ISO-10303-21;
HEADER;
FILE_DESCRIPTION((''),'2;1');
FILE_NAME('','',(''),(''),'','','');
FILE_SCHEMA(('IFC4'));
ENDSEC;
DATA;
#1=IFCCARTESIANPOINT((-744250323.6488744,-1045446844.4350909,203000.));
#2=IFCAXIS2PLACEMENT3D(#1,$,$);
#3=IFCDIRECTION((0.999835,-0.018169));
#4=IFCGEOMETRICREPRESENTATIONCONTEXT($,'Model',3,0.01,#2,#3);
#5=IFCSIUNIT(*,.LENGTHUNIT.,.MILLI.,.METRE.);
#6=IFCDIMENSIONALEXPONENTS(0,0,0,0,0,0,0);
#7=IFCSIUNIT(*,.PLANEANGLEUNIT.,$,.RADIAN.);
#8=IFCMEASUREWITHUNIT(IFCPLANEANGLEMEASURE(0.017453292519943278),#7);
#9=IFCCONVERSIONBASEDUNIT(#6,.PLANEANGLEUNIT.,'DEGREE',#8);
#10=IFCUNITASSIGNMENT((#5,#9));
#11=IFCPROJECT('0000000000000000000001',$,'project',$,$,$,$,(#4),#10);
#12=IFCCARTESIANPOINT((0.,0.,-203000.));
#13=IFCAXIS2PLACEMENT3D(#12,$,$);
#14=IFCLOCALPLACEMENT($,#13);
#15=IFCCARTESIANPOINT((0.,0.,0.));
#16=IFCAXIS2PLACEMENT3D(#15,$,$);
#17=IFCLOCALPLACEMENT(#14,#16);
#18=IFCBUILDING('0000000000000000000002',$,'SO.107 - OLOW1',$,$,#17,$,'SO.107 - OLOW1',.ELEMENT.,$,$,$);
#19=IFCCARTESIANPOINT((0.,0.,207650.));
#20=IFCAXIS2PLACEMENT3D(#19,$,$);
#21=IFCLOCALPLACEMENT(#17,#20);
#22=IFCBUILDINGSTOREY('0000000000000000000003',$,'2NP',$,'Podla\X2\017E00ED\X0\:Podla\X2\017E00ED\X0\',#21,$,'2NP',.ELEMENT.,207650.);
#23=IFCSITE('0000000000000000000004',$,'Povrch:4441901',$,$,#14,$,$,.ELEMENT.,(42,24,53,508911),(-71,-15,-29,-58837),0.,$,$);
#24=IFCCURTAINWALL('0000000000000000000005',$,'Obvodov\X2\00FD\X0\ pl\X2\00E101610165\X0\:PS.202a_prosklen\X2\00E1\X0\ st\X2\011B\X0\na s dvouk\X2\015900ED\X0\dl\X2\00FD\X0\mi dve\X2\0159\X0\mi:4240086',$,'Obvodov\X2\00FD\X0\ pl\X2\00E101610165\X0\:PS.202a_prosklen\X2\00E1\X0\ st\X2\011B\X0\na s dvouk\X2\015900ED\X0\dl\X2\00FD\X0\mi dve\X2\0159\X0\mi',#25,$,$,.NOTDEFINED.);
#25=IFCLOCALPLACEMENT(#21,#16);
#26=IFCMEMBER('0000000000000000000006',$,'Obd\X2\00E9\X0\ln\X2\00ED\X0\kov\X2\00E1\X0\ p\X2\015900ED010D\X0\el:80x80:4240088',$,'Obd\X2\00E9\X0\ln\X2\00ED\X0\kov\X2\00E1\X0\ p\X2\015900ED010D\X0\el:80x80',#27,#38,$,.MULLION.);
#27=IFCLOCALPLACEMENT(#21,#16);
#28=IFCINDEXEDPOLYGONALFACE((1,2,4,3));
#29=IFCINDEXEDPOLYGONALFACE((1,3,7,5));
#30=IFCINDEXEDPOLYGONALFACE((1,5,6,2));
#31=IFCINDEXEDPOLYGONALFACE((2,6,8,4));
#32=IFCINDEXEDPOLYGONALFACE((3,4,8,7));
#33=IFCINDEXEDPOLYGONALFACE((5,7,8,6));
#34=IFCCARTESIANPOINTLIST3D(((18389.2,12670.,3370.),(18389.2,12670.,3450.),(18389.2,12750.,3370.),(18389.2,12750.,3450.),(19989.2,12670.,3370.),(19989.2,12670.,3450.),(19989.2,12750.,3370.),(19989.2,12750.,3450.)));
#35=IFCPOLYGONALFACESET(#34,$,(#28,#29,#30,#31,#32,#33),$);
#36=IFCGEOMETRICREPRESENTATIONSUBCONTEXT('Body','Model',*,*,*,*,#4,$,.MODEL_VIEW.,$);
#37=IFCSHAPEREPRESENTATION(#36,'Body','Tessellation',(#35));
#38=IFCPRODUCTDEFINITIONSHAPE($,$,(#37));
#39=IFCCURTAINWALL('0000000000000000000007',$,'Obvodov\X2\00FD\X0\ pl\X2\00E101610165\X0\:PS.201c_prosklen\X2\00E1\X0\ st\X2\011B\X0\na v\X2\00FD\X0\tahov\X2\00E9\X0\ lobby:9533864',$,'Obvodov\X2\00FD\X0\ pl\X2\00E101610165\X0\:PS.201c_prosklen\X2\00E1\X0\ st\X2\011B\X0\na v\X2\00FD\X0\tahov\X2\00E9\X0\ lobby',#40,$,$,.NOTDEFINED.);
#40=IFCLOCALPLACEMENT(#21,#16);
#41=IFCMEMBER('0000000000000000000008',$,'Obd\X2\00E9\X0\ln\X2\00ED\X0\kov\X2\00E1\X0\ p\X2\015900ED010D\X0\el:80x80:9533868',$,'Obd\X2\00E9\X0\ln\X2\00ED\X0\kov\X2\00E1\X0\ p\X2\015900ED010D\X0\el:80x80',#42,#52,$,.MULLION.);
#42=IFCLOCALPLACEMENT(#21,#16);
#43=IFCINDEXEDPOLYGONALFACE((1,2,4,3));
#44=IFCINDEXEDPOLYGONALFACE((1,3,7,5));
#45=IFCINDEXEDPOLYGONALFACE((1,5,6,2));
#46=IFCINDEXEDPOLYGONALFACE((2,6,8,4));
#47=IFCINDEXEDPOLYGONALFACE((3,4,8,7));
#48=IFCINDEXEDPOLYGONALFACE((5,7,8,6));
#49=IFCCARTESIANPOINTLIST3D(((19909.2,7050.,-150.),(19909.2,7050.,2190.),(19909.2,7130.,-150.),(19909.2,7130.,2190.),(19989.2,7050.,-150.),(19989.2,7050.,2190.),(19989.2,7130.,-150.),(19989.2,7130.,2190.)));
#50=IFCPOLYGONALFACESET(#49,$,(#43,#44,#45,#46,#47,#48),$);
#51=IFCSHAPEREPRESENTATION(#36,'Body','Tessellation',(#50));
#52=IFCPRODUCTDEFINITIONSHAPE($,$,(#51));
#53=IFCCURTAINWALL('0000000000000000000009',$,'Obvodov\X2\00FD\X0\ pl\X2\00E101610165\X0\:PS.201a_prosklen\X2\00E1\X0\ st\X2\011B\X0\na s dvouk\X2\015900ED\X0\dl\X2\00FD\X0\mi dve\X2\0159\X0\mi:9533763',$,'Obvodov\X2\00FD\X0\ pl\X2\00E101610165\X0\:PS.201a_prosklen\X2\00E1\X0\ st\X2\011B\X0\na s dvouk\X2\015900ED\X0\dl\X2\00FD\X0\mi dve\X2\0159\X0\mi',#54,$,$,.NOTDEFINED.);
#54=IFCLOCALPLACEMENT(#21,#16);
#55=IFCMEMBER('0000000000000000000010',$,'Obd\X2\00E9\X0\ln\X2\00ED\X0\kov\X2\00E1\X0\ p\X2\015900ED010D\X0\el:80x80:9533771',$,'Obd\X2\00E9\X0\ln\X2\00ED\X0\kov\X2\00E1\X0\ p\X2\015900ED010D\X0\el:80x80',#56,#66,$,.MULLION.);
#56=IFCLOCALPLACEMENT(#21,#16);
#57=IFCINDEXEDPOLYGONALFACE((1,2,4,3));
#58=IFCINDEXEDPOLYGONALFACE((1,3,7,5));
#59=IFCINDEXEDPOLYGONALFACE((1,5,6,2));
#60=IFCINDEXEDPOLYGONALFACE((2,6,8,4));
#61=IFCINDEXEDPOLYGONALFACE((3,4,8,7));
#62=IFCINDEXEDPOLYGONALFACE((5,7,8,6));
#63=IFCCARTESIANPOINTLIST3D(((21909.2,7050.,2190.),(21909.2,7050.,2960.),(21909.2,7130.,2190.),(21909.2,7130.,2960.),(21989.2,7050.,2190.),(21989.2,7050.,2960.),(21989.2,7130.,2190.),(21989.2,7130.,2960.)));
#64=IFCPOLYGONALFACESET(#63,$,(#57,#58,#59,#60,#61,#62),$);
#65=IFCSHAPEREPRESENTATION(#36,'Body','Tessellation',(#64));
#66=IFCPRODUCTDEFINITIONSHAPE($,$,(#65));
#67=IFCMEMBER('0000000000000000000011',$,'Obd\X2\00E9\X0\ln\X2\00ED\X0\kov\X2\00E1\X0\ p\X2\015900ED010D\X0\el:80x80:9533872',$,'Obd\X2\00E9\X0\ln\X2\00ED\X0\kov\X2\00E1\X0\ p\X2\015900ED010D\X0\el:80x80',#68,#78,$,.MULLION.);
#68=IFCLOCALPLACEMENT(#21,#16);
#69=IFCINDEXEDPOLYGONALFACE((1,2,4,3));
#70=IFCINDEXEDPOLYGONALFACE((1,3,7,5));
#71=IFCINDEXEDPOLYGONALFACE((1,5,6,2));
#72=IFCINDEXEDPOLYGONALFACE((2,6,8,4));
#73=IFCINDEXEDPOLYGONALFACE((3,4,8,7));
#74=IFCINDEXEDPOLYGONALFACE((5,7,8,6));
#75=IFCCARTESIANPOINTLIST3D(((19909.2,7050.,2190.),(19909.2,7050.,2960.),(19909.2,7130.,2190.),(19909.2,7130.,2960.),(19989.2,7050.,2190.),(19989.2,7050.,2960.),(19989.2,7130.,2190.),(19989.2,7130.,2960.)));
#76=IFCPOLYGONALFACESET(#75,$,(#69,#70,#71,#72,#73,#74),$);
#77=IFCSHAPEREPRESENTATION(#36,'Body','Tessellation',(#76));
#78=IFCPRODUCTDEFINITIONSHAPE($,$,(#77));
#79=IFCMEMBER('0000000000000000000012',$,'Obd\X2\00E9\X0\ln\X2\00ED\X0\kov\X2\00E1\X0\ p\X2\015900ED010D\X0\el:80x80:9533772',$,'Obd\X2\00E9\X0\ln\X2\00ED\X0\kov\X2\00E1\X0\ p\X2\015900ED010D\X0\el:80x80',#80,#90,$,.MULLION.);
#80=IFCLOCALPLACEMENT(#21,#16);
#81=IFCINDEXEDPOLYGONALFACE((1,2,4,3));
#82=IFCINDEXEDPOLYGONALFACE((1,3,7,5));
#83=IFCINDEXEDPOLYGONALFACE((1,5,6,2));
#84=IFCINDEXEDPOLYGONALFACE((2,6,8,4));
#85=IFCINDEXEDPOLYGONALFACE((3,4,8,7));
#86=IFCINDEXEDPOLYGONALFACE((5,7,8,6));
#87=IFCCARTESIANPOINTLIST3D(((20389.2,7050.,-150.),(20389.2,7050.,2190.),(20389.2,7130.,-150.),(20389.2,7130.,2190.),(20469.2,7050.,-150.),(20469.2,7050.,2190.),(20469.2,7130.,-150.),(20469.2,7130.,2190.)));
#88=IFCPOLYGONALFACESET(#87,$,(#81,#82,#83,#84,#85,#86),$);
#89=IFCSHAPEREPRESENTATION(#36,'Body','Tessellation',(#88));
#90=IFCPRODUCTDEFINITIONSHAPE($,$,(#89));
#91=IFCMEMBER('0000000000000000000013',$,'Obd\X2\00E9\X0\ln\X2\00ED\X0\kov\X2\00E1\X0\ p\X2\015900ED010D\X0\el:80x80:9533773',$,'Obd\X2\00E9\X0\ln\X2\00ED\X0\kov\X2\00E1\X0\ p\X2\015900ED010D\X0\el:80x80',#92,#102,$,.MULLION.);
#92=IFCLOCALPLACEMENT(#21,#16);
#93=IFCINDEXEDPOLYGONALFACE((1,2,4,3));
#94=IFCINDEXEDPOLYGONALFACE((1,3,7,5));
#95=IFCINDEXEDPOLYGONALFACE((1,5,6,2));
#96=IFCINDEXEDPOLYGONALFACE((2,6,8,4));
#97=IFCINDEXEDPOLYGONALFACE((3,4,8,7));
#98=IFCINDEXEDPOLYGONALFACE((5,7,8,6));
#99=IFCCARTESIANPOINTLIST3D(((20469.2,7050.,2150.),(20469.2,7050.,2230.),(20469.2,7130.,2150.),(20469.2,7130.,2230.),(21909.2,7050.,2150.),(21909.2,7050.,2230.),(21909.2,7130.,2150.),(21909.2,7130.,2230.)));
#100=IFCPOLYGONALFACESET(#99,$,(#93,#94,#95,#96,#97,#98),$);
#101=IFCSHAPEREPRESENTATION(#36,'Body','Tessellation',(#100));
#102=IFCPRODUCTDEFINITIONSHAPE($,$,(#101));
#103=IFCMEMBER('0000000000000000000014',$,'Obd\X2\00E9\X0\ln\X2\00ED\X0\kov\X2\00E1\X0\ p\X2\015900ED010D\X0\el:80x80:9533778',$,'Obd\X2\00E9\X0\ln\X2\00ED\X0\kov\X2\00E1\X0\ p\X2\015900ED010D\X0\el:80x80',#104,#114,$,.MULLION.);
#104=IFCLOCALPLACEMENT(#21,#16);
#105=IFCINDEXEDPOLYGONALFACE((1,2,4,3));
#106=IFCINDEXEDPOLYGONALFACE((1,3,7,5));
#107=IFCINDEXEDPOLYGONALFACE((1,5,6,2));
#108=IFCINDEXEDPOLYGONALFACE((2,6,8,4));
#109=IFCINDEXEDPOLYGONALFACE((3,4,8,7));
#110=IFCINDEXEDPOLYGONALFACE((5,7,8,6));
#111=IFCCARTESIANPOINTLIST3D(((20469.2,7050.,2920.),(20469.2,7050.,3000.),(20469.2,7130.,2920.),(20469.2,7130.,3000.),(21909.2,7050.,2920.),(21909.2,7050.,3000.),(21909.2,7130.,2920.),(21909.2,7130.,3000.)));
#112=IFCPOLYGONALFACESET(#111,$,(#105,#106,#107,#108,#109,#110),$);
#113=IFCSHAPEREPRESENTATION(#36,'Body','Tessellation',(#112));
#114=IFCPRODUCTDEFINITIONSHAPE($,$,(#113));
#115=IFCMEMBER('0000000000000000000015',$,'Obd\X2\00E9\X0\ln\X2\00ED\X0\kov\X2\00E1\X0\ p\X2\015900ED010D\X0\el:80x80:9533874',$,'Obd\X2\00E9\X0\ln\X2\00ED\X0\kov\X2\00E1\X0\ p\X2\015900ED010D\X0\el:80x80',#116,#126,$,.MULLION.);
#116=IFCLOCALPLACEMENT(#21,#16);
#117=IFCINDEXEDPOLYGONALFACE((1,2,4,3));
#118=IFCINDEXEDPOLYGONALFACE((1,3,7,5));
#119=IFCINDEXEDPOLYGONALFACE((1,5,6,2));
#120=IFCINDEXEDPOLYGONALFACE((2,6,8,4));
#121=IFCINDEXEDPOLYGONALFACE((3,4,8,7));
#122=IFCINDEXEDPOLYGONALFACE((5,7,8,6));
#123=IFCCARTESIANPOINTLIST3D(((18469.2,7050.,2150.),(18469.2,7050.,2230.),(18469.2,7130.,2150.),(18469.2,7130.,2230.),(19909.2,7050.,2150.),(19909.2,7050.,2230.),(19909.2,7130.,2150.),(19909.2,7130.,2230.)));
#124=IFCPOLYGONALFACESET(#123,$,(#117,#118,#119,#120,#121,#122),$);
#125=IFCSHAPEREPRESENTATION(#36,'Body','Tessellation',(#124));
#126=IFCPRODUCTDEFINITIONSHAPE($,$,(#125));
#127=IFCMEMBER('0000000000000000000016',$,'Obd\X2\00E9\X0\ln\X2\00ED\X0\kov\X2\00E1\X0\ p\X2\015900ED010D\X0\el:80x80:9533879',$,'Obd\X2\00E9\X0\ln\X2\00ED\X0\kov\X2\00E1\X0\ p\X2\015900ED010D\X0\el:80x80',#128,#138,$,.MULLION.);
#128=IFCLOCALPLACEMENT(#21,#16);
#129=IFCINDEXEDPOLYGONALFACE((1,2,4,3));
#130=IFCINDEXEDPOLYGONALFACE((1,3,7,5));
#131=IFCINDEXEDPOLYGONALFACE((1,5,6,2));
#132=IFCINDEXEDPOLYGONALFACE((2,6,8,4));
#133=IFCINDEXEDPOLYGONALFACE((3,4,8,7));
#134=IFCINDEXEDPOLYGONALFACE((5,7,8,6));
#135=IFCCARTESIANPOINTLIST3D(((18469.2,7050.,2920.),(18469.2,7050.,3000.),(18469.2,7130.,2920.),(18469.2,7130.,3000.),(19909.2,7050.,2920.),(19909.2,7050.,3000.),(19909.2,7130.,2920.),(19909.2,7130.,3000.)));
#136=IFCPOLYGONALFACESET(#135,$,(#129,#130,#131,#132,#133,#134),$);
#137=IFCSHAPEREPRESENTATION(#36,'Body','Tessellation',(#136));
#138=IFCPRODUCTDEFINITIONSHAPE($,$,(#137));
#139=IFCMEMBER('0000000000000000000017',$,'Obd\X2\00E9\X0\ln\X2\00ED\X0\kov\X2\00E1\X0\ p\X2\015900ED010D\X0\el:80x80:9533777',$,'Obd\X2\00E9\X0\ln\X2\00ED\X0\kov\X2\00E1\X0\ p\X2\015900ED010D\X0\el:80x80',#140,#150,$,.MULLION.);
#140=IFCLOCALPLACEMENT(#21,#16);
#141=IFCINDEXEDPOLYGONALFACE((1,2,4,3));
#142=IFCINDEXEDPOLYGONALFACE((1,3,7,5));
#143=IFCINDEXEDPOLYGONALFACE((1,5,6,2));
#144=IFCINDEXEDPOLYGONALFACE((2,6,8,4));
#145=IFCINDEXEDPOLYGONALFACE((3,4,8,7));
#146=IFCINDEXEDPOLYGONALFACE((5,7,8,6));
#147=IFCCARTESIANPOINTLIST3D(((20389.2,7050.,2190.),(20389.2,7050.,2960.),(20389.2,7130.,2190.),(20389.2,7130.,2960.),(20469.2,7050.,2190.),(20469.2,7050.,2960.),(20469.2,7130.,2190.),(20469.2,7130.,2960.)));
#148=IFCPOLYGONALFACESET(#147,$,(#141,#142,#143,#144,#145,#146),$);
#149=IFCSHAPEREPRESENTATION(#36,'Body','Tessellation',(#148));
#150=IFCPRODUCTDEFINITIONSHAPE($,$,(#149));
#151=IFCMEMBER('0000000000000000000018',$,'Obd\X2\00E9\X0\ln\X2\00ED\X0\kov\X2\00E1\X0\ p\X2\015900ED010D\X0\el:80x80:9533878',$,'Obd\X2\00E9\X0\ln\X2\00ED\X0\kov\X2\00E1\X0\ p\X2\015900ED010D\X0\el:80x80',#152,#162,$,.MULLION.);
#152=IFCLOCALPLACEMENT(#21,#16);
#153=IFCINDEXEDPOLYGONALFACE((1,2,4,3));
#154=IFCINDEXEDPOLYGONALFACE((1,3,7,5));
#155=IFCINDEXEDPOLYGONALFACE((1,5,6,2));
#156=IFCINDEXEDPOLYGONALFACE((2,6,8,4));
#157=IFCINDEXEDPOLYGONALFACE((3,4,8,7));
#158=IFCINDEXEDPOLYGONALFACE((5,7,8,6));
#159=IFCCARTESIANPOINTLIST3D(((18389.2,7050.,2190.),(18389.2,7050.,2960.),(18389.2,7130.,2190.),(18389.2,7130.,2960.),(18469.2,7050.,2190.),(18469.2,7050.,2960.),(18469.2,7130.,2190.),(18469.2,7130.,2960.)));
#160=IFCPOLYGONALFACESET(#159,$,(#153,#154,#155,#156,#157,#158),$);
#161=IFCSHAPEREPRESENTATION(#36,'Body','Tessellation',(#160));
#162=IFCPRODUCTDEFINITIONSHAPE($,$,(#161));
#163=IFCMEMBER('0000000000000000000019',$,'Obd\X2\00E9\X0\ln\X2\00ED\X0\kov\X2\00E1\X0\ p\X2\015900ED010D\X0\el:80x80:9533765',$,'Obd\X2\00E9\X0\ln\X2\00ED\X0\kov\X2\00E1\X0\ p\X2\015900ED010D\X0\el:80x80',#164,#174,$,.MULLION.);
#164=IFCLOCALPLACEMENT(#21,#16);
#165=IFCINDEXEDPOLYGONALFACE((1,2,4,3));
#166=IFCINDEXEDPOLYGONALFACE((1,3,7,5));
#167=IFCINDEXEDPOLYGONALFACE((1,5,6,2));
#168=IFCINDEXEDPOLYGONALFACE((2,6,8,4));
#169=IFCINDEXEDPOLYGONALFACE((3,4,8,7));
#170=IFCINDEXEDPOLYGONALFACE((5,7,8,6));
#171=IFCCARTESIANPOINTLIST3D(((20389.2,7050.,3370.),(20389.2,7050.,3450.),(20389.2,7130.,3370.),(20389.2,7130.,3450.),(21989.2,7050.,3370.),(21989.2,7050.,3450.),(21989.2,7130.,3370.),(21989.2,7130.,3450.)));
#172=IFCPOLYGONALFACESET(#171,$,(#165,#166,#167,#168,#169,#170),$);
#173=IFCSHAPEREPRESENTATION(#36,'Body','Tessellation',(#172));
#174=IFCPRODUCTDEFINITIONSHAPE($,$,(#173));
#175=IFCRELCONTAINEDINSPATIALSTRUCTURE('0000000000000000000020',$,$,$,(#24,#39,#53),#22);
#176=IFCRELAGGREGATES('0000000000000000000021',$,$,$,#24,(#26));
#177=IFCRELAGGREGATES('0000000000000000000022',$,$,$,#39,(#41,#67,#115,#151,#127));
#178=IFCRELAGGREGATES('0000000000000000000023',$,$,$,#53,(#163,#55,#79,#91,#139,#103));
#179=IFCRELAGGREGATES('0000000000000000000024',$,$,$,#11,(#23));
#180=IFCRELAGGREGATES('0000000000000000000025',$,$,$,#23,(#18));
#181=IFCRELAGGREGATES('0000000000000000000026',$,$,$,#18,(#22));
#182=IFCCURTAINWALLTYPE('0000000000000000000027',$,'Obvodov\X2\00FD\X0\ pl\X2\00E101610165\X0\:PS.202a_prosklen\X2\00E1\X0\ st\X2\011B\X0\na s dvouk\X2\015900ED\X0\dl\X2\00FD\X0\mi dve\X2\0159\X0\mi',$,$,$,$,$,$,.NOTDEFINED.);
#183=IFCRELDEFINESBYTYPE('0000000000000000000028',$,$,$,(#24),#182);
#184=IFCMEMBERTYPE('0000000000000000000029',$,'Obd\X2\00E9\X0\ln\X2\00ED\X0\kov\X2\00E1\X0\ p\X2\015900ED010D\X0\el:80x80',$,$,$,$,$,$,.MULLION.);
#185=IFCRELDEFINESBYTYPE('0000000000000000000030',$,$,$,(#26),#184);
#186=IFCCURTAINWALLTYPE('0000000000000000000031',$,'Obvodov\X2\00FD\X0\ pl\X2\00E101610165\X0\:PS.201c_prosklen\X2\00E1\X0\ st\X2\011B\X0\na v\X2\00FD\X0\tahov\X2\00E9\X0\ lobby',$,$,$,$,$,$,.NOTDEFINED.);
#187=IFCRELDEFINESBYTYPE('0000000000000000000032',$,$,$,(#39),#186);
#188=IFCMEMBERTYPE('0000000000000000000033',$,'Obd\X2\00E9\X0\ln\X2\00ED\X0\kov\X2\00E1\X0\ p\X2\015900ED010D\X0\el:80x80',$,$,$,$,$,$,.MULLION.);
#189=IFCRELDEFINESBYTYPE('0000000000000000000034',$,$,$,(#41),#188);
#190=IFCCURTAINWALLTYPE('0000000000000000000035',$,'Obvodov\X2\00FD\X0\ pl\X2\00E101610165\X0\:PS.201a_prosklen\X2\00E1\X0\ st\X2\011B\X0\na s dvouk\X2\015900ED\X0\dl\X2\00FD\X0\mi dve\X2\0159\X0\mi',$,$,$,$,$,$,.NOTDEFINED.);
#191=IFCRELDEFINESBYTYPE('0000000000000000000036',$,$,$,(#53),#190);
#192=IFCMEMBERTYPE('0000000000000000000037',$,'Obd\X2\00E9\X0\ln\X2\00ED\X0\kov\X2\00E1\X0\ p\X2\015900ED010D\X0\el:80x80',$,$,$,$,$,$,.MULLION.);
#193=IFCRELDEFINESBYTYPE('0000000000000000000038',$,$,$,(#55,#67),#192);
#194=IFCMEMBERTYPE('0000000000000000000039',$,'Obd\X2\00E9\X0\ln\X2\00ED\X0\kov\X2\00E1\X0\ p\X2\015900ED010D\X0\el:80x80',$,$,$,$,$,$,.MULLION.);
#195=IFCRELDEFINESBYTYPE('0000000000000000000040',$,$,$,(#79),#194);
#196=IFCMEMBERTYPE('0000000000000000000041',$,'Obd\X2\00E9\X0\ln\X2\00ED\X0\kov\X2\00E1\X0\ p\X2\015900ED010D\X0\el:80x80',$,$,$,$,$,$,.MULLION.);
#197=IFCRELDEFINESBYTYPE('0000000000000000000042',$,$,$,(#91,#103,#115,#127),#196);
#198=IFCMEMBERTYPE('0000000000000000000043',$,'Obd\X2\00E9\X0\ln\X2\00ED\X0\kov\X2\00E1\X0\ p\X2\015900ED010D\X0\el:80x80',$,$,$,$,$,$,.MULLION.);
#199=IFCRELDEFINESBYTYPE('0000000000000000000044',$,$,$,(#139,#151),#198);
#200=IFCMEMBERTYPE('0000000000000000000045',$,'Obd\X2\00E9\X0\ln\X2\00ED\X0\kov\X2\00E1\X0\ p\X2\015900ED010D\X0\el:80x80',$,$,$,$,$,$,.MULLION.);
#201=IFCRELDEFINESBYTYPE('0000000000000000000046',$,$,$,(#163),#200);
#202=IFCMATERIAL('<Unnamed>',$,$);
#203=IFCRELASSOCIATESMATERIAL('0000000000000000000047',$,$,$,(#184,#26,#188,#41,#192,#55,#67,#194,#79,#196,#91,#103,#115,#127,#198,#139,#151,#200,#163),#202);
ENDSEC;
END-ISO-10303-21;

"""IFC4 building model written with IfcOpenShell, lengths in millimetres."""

from ifc_helpers import new_model, entity, si_unit, converted_unit, direction, frame, origin, place, context, subcontext, project, spatial, indexed_curve, outline, extrude, source, transform, mapped, material, type_object, type_shapes, element, aggregate, save


model = new_model("IFC4")

# Units and contexts
model_context = context("Model", 3, precision=0.01, world=frame((-744250323.6488744, -1045446844.4350909, 203000.0)), true_north=direction((0.999835, -0.018169)))
body_context = subcontext(model_context, "Body", "Model", "MODEL_VIEW")
ifc_project = project(units=[si_unit("LENGTHUNIT", "METRE", prefix="MILLI"), converted_unit("PLANEANGLEUNIT", "DEGREE", entity("IfcPlaneAngleMeasure", 0.017453292519943278), si_unit("PLANEANGLEUNIT", "RADIAN"), dimensions=[0, 0, 0, 0, 0, 0, 0])], contexts=[model_context])

# Site, building, storey
site_placement = place(None, frame((0.0, 0.0, -203000.0)))
site = spatial("IfcSite", under=ifc_project, at=site_placement, Name="Povrch:4441901", CompositionType="ELEMENT", RefLatitude=(42, 24, 53, 508911), RefLongitude=(-71, -15, -29, -58837), RefElevation=0.0)
building_placement = place(site_placement, origin())
building = spatial("IfcBuilding", under=site, at=building_placement, Name="SO.107 - OLOW1", LongName="SO.107 - OLOW1", CompositionType="ELEMENT")
storey_placement = place(building_placement, frame((0.0, 0.0, 207650.0)))
storey = spatial("IfcBuildingStorey", under=building, at=storey_placement, Name="2NP", ObjectType="Podlaží:Podlaží", LongName="2NP", CompositionType="ELEMENT", Elevation=207650.0)

# Curtain walls, members
curtain_wall_type_1 = type_object("IfcCurtainWallType", Name="Obvodový plášť:PS.202a_prosklená stěna s dvoukřídlými dveřmi", PredefinedType="NOTDEFINED")
curtain_wall_1_placement = place(storey_placement, frame((0.0, 0.0, -207650.0)))
curtain_wall_1 = element("IfcCurtainWall", 1, at=curtain_wall_1_placement, inside=storey, type_object=curtain_wall_type_1, Name="Obvodový plášť:PS.202a_prosklená stěna s dvoukřídlými dveřmi:4240086", ObjectType="Obvodový plášť:PS.202a_prosklená stěna s dvoukřídlými dveřmi", PredefinedType="NOTDEFINED")
ifc_material_1 = material(Name="<Unnamed>")
member_type_1 = type_object("IfcMemberType", Name="Obdélníková příčel:80x80", PredefinedType="MULLION", material=ifc_material_1)
shared_shape_1 = source(origin(), body_context, "Body", "SweptSolid", [
    extrude(outline(indexed_curve([(-40.0, -40.0), (40.0, -40.0), (40.0, 40.0), (-40.0, 40.0), (-40.0, -40.0)], self_intersect=False)), frame((-40.0, 0.0, -1600.0), z_axis=(0.0, 0.0, 1.0), x_axis=(-1.0, 0.0, 0.0)), (0.0, 0.0, 1.0), 1600.0),
])
type_shapes(member_type_1, [shared_shape_1])
member_1_placement = place(curtain_wall_1_placement, frame((19989.2, 12710.0, 211100.0), z_axis=(1.0, 0.0, 0.0), x_axis=(0.0, 0.0, 1.0)))
member_1 = element("IfcMember", 2, at=member_1_placement, type_object=member_type_1, material=ifc_material_1, Name="Obdélníková příčel:80x80:4240088", ObjectType="Obdélníková příčel:80x80", PredefinedType="MULLION", context=body_context, shape_type="MappedRepresentation", body=[
    mapped(shared_shape_1, transform((0.0, 0.0, 0.0), scale=1.0)),
])
aggregate(curtain_wall_1, [member_1])
curtain_wall_type_2 = type_object("IfcCurtainWallType", Name="Obvodový plášť:PS.201c_prosklená stěna výtahové lobby", PredefinedType="NOTDEFINED")
curtain_wall_2_placement = place(storey_placement, frame((0.0, 0.0, -207650.0)))
curtain_wall_2 = element("IfcCurtainWall", 3, at=curtain_wall_2_placement, inside=storey, type_object=curtain_wall_type_2, Name="Obvodový plášť:PS.201c_prosklená stěna výtahové lobby:9533864", ObjectType="Obvodový plášť:PS.201c_prosklená stěna výtahové lobby", PredefinedType="NOTDEFINED")
member_type_2 = type_object("IfcMemberType", Name="Obdélníková příčel:80x80", PredefinedType="MULLION", material=ifc_material_1)
shared_shape_2 = source(origin(), body_context, "Body", "SweptSolid", [
    extrude(outline(indexed_curve([(-40.0, -40.0), (40.0, -40.0), (40.0, 40.0), (-40.0, 40.0), (-40.0, -40.0)], self_intersect=False)), frame((-40.0, 0.0, -2340.0), z_axis=(0.0, 0.0, 1.0), x_axis=(-1.0, 0.0, 0.0)), (0.0, 0.0, 1.0), 2340.0),
])
type_shapes(member_type_2, [shared_shape_2])
member_2_placement = place(curtain_wall_2_placement, frame((19989.2, 7090.0, 207500.0), z_axis=(0.0, 0.0, -1.0), x_axis=(1.0, 0.0, 0.0)))
member_2 = element("IfcMember", 4, at=member_2_placement, type_object=member_type_2, material=ifc_material_1, Name="Obdélníková příčel:80x80:9533868", ObjectType="Obdélníková příčel:80x80", PredefinedType="MULLION", context=body_context, shape_type="MappedRepresentation", body=[
    mapped(shared_shape_2, transform((0.0, 0.0, 0.0), scale=1.0)),
])
curtain_wall_type_3 = type_object("IfcCurtainWallType", Name="Obvodový plášť:PS.201a_prosklená stěna s dvoukřídlými dveřmi", PredefinedType="NOTDEFINED")
curtain_wall_3_placement = place(storey_placement, frame((0.0, 0.0, -207650.0)))
curtain_wall_3 = element("IfcCurtainWall", 5, at=curtain_wall_3_placement, inside=storey, type_object=curtain_wall_type_3, Name="Obvodový plášť:PS.201a_prosklená stěna s dvoukřídlými dveřmi:9533763", ObjectType="Obvodový plášť:PS.201a_prosklená stěna s dvoukřídlými dveřmi", PredefinedType="NOTDEFINED")
member_type_3 = type_object("IfcMemberType", Name="Obdélníková příčel:80x80", PredefinedType="MULLION", material=ifc_material_1)
shared_shape_3 = source(origin(), body_context, "Body", "SweptSolid", [
    extrude(outline(indexed_curve([(-40.0, -40.0), (40.0, -40.0), (40.0, 40.0), (-40.0, 40.0), (-40.0, -40.0)], self_intersect=False)), frame((-40.0, 0.0, -770.0), z_axis=(0.0, 0.0, 1.0), x_axis=(-1.0, 0.0, 0.0)), (0.0, 0.0, 1.0), 770.0),
])
type_shapes(member_type_3, [shared_shape_3])
member_3_placement = place(curtain_wall_3_placement, frame((21989.2, 7090.0, 209840.0), z_axis=(0.0, 0.0, -1.0), x_axis=(1.0, 0.0, 0.0)))
member_3 = element("IfcMember", 6, at=member_3_placement, type_object=member_type_3, material=ifc_material_1, Name="Obdélníková příčel:80x80:9533771", ObjectType="Obdélníková příčel:80x80", PredefinedType="MULLION", context=body_context, shape_type="MappedRepresentation", body=[
    mapped(shared_shape_3, transform((0.0, 0.0, 0.0), scale=1.0)),
])

# Members
member_4_placement = place(curtain_wall_2_placement, frame((19989.2, 7090.0, 209840.0), z_axis=(0.0, 0.0, -1.0), x_axis=(1.0, 0.0, 0.0)))
member_4 = element("IfcMember", 7, at=member_4_placement, type_object=member_type_3, material=ifc_material_1, Name="Obdélníková příčel:80x80:9533872", ObjectType="Obdélníková příčel:80x80", PredefinedType="MULLION", context=body_context, shape_type="MappedRepresentation", body=[
    mapped(shared_shape_3, transform((0.0, 0.0, 0.0), scale=1.0)),
])
member_type_4 = type_object("IfcMemberType", Name="Obdélníková příčel:80x80", PredefinedType="MULLION", material=ifc_material_1)
shared_shape_4 = source(origin(), body_context, "Body", "SweptSolid", [
    extrude(outline(indexed_curve([(-40.0, -40.0), (40.0, -40.0), (40.0, 40.0), (-40.0, 40.0), (-40.0, -40.0)], self_intersect=False)), frame((-40.0, 0.0, -2340.0), z_axis=(0.0, 0.0, 1.0), x_axis=(-1.0, 0.0, 0.0)), (0.0, 0.0, 1.0), 2340.0),
])
type_shapes(member_type_4, [shared_shape_4])
member_5_placement = place(curtain_wall_3_placement, frame((20389.2, 7090.0, 209840.0), z_axis=(0.0, 0.0, 1.0), x_axis=(-1.0, 0.0, 0.0)))
member_5 = element("IfcMember", 8, at=member_5_placement, type_object=member_type_4, material=ifc_material_1, Name="Obdélníková příčel:80x80:9533772", ObjectType="Obdélníková příčel:80x80", PredefinedType="MULLION", context=body_context, shape_type="MappedRepresentation", body=[
    mapped(shared_shape_4, transform((0.0, 0.0, 0.0), scale=1.0)),
])
member_type_5 = type_object("IfcMemberType", Name="Obdélníková příčel:80x80", PredefinedType="MULLION", material=ifc_material_1)
shared_shape_5 = source(origin(), body_context, "Body", "SweptSolid", [
    extrude(outline(indexed_curve([(-40.0, -40.0), (40.0, -40.0), (40.0, 40.0), (-40.0, 40.0), (-40.0, -40.0)], self_intersect=False)), frame((0.0, 0.0, -1440.0), z_axis=(0.0, 0.0, 1.0), x_axis=(-1.0, 0.0, 0.0)), (0.0, 0.0, 1.0), 1440.0),
])
type_shapes(member_type_5, [shared_shape_5])
member_6_placement = place(curtain_wall_3_placement, frame((21909.2, 7090.0, 209840.0), z_axis=(1.0, 0.0, 0.0), x_axis=(0.0, 0.0, 1.0)))
member_6 = element("IfcMember", 9, at=member_6_placement, type_object=member_type_5, material=ifc_material_1, Name="Obdélníková příčel:80x80:9533773", ObjectType="Obdélníková příčel:80x80", PredefinedType="MULLION", context=body_context, shape_type="MappedRepresentation", body=[
    mapped(shared_shape_5, transform((0.0, 0.0, 0.0), scale=1.0)),
])
member_7_placement = place(curtain_wall_3_placement, frame((21909.2, 7090.0, 210610.0), z_axis=(1.0, 0.0, 0.0), x_axis=(0.0, 0.0, 1.0)))
member_7 = element("IfcMember", 10, at=member_7_placement, type_object=member_type_5, material=ifc_material_1, Name="Obdélníková příčel:80x80:9533778", ObjectType="Obdélníková příčel:80x80", PredefinedType="MULLION", context=body_context, shape_type="MappedRepresentation", body=[
    mapped(shared_shape_5, transform((0.0, 0.0, 0.0), scale=1.0)),
])
member_8_placement = place(curtain_wall_2_placement, frame((19909.2, 7090.0, 209840.0), z_axis=(1.0, 0.0, 0.0), x_axis=(0.0, 0.0, 1.0)))
member_8 = element("IfcMember", 11, at=member_8_placement, type_object=member_type_5, material=ifc_material_1, Name="Obdélníková příčel:80x80:9533874", ObjectType="Obdélníková příčel:80x80", PredefinedType="MULLION", context=body_context, shape_type="MappedRepresentation", body=[
    mapped(shared_shape_5, transform((0.0, 0.0, 0.0), scale=1.0)),
])
member_9_placement = place(curtain_wall_2_placement, frame((19909.2, 7090.0, 210610.0), z_axis=(1.0, 0.0, 0.0), x_axis=(0.0, 0.0, 1.0)))
member_9 = element("IfcMember", 12, at=member_9_placement, type_object=member_type_5, material=ifc_material_1, Name="Obdélníková příčel:80x80:9533879", ObjectType="Obdélníková příčel:80x80", PredefinedType="MULLION", context=body_context, shape_type="MappedRepresentation", body=[
    mapped(shared_shape_5, transform((0.0, 0.0, 0.0), scale=1.0)),
])
member_type_6 = type_object("IfcMemberType", Name="Obdélníková příčel:80x80", PredefinedType="MULLION", material=ifc_material_1)
shared_shape_6 = source(origin(), body_context, "Body", "SweptSolid", [
    extrude(outline(indexed_curve([(-40.0, -40.0), (40.0, -40.0), (40.0, 40.0), (-40.0, 40.0), (-40.0, -40.0)], self_intersect=False)), frame((-40.0, 0.0, -770.0), z_axis=(0.0, 0.0, 1.0), x_axis=(-1.0, 0.0, 0.0)), (0.0, 0.0, 1.0), 770.0),
])
type_shapes(member_type_6, [shared_shape_6])
member_10_placement = place(curtain_wall_3_placement, frame((20389.2, 7090.0, 210610.0), z_axis=(0.0, 0.0, 1.0), x_axis=(-1.0, 0.0, 0.0)))
member_10 = element("IfcMember", 13, at=member_10_placement, type_object=member_type_6, material=ifc_material_1, Name="Obdélníková příčel:80x80:9533777", ObjectType="Obdélníková příčel:80x80", PredefinedType="MULLION", context=body_context, shape_type="MappedRepresentation", body=[
    mapped(shared_shape_6, transform((0.0, 0.0, 0.0), scale=1.0)),
])
member_11_placement = place(curtain_wall_2_placement, frame((18389.2, 7090.0, 210610.0), z_axis=(0.0, 0.0, 1.0), x_axis=(-1.0, 0.0, 0.0)))
member_11 = element("IfcMember", 14, at=member_11_placement, type_object=member_type_6, material=ifc_material_1, Name="Obdélníková příčel:80x80:9533878", ObjectType="Obdélníková příčel:80x80", PredefinedType="MULLION", context=body_context, shape_type="MappedRepresentation", body=[
    mapped(shared_shape_6, transform((0.0, 0.0, 0.0), scale=1.0)),
])
member_type_7 = type_object("IfcMemberType", Name="Obdélníková příčel:80x80", PredefinedType="MULLION", material=ifc_material_1)
shared_shape_7 = source(origin(), body_context, "Body", "SweptSolid", [
    extrude(outline(indexed_curve([(-40.0, -40.0), (40.0, -40.0), (40.0, 40.0), (-40.0, 40.0), (-40.0, -40.0)], self_intersect=False)), frame((-40.0, 0.0, -1600.0), z_axis=(0.0, 0.0, 1.0), x_axis=(-1.0, 0.0, 0.0)), (0.0, 0.0, 1.0), 1600.0),
])
type_shapes(member_type_7, [shared_shape_7])
member_12_placement = place(curtain_wall_3_placement, frame((21989.2, 7090.0, 211100.0), z_axis=(1.0, 0.0, 0.0), x_axis=(0.0, 0.0, 1.0)))
member_12 = element("IfcMember", 15, at=member_12_placement, type_object=member_type_7, material=ifc_material_1, Name="Obdélníková příčel:80x80:9533765", ObjectType="Obdélníková příčel:80x80", PredefinedType="MULLION", context=body_context, shape_type="MappedRepresentation", body=[
    mapped(shared_shape_7, transform((0.0, 0.0, 0.0), scale=1.0)),
])

aggregate(curtain_wall_2, [member_2, member_4, member_8, member_11, member_9])

aggregate(curtain_wall_3, [member_12, member_3, member_5, member_6, member_10, member_7])

save(model, "model.ifc")
